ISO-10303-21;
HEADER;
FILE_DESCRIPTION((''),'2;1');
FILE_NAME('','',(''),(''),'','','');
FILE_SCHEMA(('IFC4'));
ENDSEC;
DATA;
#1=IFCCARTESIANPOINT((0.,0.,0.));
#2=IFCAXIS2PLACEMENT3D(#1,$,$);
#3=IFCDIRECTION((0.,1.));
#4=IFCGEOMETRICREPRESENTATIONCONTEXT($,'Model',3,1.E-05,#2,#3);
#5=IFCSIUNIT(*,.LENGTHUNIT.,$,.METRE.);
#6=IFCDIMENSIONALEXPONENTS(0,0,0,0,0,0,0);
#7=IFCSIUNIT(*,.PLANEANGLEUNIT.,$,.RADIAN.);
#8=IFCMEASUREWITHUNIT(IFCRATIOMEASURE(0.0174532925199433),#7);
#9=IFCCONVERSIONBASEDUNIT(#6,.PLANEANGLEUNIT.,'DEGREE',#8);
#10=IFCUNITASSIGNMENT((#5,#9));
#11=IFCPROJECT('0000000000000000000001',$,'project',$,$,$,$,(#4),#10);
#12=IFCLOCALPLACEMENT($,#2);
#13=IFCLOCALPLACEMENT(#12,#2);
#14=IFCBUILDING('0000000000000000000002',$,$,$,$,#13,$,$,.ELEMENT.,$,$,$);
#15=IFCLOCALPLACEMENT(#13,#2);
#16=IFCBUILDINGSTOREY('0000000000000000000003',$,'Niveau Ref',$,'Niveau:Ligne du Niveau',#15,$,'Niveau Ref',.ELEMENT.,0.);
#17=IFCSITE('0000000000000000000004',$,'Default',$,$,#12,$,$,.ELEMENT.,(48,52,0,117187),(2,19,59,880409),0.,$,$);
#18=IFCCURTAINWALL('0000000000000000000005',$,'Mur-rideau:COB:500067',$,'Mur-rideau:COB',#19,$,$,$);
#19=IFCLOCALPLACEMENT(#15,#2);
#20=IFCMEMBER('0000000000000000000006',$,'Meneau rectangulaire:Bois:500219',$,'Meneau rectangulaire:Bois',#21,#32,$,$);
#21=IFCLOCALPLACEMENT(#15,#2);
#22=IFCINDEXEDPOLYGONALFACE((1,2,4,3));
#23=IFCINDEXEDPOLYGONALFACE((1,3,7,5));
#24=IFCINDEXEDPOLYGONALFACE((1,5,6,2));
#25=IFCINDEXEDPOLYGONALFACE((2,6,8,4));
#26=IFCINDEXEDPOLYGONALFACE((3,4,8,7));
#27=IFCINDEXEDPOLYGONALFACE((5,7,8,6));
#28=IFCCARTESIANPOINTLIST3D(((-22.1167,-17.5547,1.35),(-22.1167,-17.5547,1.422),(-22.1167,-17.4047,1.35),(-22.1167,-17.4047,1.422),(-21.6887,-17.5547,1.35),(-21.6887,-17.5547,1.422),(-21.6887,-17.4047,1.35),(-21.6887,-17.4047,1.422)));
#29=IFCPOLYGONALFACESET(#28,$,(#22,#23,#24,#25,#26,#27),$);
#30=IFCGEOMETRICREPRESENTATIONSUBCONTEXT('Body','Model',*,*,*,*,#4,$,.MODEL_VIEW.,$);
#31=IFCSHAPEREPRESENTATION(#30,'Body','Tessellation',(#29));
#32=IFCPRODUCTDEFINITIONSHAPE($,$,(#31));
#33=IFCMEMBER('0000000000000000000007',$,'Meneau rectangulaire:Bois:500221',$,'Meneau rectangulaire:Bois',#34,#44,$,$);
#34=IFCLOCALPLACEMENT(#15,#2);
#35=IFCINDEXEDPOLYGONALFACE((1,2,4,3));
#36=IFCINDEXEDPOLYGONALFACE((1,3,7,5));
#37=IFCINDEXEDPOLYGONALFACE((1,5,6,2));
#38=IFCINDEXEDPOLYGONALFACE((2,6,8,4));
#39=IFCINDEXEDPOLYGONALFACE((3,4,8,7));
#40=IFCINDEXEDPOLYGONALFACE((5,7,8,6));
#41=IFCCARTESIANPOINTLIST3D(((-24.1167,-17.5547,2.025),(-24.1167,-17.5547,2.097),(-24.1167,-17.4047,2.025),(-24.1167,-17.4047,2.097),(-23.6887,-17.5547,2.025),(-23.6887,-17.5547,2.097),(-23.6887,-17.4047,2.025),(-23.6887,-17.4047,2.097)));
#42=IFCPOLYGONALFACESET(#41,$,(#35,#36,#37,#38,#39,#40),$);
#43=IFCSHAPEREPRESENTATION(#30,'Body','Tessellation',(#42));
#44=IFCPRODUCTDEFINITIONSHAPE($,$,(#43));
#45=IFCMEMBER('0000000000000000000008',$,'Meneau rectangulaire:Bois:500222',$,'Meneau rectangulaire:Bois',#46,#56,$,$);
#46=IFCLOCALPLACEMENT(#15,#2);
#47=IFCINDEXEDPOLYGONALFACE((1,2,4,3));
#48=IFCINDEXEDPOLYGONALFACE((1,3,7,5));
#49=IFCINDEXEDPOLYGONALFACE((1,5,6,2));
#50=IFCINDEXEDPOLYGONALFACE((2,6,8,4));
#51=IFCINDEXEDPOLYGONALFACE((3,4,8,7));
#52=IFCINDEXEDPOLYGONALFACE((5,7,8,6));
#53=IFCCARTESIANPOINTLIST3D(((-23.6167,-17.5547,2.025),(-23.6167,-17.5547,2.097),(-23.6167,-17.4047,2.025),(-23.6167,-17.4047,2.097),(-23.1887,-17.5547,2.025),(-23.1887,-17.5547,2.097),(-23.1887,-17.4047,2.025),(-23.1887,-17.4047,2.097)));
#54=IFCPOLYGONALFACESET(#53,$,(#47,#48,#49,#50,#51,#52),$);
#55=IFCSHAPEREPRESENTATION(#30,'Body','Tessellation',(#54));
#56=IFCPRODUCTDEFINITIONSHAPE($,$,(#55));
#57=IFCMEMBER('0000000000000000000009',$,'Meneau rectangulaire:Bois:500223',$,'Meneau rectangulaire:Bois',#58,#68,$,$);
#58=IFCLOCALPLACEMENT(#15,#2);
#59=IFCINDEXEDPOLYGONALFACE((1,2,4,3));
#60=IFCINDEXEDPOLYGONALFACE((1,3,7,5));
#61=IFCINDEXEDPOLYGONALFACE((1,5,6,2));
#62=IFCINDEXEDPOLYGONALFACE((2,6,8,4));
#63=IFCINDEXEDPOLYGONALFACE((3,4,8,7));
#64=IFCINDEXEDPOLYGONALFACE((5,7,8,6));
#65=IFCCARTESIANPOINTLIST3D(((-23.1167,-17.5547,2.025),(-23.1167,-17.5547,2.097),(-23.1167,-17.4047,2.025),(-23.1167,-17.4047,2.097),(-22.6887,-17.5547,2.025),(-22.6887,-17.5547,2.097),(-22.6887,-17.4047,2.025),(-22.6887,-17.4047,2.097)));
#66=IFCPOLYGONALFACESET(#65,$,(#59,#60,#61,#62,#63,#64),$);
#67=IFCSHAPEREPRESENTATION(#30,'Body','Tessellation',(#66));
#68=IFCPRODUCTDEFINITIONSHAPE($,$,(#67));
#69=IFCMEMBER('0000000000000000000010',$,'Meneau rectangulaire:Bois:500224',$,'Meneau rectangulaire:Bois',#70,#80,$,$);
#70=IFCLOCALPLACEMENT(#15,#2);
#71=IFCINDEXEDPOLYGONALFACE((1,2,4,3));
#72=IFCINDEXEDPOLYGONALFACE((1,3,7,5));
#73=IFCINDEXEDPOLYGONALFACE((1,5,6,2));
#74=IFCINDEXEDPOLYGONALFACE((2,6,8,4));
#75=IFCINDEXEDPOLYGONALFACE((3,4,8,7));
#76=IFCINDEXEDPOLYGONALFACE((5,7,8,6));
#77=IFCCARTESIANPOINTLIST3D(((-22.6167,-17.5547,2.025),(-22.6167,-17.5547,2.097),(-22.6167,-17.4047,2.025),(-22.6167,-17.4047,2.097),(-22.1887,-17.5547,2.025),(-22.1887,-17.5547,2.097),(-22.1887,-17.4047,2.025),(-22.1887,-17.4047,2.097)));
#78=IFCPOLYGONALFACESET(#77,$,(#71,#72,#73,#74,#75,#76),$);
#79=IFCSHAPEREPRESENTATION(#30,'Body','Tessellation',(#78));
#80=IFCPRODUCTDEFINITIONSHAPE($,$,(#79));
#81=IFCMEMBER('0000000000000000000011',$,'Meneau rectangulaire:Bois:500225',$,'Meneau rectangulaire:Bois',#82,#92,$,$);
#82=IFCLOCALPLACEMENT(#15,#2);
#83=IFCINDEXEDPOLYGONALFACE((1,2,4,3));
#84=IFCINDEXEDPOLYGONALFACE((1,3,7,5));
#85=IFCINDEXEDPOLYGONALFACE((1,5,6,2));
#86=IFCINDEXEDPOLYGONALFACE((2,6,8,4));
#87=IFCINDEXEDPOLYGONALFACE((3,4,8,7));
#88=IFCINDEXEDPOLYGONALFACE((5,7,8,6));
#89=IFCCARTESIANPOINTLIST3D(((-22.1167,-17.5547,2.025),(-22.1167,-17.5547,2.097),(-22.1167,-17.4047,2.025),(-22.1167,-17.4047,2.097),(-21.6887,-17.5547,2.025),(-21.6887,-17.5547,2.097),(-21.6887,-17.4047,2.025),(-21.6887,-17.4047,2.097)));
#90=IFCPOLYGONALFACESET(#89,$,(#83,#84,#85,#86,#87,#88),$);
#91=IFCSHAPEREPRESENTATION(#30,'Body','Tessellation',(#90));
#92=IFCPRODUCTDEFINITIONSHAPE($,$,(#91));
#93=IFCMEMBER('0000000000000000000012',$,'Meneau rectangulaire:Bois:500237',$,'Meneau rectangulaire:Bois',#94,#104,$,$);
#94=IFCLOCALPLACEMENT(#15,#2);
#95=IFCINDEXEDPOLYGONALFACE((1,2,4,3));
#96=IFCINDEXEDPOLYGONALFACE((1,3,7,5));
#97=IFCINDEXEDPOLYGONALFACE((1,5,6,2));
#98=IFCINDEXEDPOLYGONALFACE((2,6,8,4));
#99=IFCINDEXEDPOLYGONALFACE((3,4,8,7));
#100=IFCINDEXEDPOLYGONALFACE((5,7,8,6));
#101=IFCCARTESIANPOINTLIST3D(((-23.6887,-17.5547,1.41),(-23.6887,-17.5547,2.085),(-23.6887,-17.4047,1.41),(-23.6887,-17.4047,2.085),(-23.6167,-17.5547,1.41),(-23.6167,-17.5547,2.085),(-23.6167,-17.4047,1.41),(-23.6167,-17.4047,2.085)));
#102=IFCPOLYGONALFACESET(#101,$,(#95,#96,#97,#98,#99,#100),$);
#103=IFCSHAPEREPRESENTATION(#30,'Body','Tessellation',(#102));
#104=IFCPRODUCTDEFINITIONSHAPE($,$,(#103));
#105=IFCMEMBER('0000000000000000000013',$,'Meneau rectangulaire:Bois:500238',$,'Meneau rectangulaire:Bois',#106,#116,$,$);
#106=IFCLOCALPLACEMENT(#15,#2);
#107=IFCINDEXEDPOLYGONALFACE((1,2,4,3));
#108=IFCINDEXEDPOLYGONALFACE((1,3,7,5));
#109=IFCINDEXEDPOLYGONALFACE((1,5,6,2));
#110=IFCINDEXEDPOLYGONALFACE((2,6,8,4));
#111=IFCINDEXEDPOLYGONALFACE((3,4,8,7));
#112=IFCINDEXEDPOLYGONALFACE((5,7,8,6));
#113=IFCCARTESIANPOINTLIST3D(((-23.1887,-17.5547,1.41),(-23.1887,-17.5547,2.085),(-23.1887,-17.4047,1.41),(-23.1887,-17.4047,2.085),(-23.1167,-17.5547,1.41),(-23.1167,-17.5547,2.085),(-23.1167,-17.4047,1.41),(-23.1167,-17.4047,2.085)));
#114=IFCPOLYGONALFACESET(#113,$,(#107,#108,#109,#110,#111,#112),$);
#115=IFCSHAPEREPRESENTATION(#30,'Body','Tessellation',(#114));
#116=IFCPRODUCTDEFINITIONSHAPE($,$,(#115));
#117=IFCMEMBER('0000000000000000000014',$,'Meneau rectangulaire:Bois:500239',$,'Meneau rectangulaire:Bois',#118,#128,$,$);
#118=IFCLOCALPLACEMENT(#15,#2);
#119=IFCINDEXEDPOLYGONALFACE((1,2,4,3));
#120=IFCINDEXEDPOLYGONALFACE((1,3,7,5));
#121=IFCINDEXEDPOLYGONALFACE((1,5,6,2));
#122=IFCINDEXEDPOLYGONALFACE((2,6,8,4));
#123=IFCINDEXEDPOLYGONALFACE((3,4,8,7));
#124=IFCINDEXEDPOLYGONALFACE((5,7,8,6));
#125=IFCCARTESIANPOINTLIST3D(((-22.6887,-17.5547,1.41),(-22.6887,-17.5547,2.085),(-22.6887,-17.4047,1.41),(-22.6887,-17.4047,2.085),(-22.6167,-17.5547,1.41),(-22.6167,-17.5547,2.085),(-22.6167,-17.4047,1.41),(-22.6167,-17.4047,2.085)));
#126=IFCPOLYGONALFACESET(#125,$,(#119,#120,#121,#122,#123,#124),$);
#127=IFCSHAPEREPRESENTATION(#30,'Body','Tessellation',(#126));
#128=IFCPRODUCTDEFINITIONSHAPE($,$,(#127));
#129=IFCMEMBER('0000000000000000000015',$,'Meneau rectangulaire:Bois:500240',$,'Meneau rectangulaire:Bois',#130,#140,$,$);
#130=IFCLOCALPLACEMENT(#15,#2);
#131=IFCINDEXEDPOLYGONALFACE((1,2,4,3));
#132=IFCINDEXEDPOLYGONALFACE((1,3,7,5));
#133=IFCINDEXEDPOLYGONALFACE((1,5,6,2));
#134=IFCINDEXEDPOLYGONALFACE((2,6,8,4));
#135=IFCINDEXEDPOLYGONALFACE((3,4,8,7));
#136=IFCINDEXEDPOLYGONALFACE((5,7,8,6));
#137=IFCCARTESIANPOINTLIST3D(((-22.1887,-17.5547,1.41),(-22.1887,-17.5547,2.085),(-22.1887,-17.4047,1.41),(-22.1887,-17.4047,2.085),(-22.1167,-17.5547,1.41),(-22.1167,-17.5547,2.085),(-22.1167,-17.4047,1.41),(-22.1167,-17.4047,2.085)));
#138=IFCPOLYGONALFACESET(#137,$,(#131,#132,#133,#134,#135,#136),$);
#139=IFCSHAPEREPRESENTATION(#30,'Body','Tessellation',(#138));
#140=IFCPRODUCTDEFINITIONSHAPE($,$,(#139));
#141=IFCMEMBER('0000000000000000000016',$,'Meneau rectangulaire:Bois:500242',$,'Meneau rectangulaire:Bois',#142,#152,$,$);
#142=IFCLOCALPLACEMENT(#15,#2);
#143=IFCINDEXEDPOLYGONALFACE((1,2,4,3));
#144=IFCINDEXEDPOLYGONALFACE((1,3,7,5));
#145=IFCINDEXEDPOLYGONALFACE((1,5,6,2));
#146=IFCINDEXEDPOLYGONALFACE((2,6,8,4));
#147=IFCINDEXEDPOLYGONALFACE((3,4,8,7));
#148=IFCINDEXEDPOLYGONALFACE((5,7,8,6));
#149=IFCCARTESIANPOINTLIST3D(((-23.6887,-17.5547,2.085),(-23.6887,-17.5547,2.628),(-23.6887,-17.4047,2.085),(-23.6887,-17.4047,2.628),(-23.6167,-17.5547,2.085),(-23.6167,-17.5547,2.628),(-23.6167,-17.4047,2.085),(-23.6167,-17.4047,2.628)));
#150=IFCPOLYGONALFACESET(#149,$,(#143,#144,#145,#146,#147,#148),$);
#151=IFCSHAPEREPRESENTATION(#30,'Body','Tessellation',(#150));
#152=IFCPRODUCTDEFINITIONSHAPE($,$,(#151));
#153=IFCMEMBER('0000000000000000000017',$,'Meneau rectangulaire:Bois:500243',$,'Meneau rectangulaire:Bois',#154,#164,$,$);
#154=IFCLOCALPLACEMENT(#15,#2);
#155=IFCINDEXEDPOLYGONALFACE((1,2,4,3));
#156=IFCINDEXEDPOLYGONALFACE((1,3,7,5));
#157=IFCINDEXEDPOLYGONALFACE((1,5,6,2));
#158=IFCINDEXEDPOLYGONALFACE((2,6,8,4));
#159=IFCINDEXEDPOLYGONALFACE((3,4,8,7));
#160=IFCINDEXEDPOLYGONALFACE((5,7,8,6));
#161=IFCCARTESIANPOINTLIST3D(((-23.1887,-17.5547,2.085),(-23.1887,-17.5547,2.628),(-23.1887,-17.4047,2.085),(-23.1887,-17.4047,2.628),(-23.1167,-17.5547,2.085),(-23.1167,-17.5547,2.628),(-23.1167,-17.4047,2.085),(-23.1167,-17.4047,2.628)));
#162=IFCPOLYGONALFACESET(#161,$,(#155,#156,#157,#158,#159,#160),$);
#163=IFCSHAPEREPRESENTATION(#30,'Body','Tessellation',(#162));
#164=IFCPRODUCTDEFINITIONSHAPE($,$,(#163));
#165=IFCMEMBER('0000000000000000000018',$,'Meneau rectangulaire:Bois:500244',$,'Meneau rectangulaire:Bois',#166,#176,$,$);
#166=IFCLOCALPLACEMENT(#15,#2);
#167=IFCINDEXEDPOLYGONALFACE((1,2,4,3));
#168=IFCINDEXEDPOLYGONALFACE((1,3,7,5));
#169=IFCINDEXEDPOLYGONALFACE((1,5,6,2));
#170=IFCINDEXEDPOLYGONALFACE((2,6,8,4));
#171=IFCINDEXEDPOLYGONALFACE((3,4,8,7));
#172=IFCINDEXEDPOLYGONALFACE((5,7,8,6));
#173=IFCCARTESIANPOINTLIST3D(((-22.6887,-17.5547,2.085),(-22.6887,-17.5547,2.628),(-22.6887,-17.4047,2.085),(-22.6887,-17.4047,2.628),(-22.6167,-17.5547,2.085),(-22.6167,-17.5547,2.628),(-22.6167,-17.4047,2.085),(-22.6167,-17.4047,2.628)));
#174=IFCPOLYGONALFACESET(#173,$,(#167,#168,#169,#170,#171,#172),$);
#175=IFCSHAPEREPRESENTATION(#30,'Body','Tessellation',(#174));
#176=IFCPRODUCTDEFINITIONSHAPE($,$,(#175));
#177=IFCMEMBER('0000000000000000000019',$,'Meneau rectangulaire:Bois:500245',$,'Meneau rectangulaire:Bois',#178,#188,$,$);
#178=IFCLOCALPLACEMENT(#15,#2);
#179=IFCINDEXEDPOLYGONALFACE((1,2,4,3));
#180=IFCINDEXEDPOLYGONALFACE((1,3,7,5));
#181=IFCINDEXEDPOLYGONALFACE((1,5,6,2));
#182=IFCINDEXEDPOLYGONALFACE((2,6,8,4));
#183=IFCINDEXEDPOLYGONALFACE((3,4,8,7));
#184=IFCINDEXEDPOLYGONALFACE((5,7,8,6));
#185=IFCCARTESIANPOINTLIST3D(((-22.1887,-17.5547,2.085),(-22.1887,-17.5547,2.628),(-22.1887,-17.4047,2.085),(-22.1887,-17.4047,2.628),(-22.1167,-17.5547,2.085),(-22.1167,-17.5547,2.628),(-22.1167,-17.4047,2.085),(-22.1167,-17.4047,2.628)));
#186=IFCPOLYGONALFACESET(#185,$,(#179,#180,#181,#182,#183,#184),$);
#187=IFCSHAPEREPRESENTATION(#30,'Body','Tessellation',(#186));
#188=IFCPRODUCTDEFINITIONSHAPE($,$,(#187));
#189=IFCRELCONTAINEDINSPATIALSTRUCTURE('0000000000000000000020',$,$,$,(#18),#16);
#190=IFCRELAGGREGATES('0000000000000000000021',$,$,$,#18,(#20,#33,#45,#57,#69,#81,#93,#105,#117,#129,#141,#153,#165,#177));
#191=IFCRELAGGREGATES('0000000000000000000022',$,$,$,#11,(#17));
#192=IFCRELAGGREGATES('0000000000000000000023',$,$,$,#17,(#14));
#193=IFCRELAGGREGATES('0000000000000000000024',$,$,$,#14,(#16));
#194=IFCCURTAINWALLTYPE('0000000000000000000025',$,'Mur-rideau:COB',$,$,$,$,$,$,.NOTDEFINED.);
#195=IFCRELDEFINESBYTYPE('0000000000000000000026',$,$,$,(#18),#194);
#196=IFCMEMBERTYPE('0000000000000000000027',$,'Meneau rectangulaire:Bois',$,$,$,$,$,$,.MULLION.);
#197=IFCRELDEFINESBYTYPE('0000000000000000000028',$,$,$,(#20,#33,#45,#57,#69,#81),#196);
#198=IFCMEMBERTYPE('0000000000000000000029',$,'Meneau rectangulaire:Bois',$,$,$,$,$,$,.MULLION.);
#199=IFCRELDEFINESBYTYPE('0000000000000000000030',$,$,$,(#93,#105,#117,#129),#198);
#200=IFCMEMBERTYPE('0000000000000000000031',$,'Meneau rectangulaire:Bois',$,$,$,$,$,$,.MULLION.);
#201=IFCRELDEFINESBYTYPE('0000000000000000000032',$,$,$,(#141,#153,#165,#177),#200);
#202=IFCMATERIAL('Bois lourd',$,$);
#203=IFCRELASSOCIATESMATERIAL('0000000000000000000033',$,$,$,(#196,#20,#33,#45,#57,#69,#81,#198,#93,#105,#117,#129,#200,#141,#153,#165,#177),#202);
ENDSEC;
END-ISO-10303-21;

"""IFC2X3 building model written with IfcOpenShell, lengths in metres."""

from ifc_helpers import new_model, entity, si_unit, converted_unit, direction, frame, origin, origin_2d_with_axis, place, context, subcontext, project, spatial, rectangle, extrude, source, transform, mapped, material, type_object, type_shapes, element, aggregate, save


model = new_model("IFC2X3")

# Units and contexts
model_context = context("Model", 3, precision=1e-05, world=origin(), true_north=direction((0.0, 1.0)))
body_context = subcontext(model_context, "Body", "Model", "MODEL_VIEW")
ifc_project = project(units=[si_unit("LENGTHUNIT", "METRE"), converted_unit("PLANEANGLEUNIT", "DEGREE", entity("IfcRatioMeasure", 0.0174532925199433), si_unit("PLANEANGLEUNIT", "RADIAN"), dimensions=[0, 0, 0, 0, 0, 0, 0])], contexts=[model_context])

# Site, building, storey
site_placement = place(None, origin())
site = spatial("IfcSite", under=ifc_project, at=site_placement, Name="Default", CompositionType="ELEMENT", RefLatitude=(48, 52, 0, 117187), RefLongitude=(2, 19, 59, 880409), RefElevation=0.0)
building_placement = place(site_placement, origin())
building = spatial("IfcBuilding", under=site, at=building_placement, CompositionType="ELEMENT")
storey_placement = place(building_placement, origin())
storey = spatial("IfcBuildingStorey", under=building, at=storey_placement, Name="Niveau Ref", ObjectType="Niveau:Ligne du Niveau", LongName="Niveau Ref", CompositionType="ELEMENT", Elevation=0.0)

# Curtain wall, members
curtain_wall_type = type_object("IfcCurtainWallType", Name="Mur-rideau:COB", PredefinedType="NOTDEFINED")
curtain_wall_placement = place(storey_placement, origin())
curtain_wall = element("IfcCurtainWall", 1, at=curtain_wall_placement, inside=storey, type_object=curtain_wall_type, Name="Mur-rideau:COB:500067", ObjectType="Mur-rideau:COB")
ifc_material = material(Name="Bois lourd")
member_type_1 = type_object("IfcMemberType", Name="Meneau rectangulaire:Bois", PredefinedType="MULLION", material=ifc_material)
shared_shape_1 = source(origin(), body_context, "Body", "SweptSolid", [
    extrude(rectangle(XDim=0.15, YDim=0.072, at=origin_2d_with_axis()), frame((-0.024, 0.0, -0.428), z_axis=(0.0, 0.0, 1.0), x_axis=(0.0, -1.0, 0.0)), (0.0, 0.0, 1.0), 0.428),
])
type_shapes(member_type_1, [shared_shape_1])
member_1_placement = place(storey_placement, frame((-21.6887, -17.4797, 1.41), z_axis=(1.0, 0.0, 0.0), x_axis=(0.0, 0.0, 1.0)))
member_1 = element("IfcMember", 2, at=member_1_placement, type_object=member_type_1, material=ifc_material, Name="Meneau rectangulaire:Bois:500219", ObjectType="Meneau rectangulaire:Bois", context=body_context, shape_type="MappedRepresentation", body=[
    mapped(shared_shape_1, transform((0.0, 0.0, 0.0), scale=1.0)),
])
member_2_placement = place(storey_placement, frame((-23.6887, -17.4797, 2.085), z_axis=(1.0, 0.0, 0.0), x_axis=(0.0, 0.0, 1.0)))
member_2 = element("IfcMember", 3, at=member_2_placement, type_object=member_type_1, material=ifc_material, Name="Meneau rectangulaire:Bois:500221", ObjectType="Meneau rectangulaire:Bois", context=body_context, shape_type="MappedRepresentation", body=[
    mapped(shared_shape_1, transform((0.0, 0.0, 0.0), scale=1.0)),
])
member_3_placement = place(storey_placement, frame((-23.1887, -17.4797, 2.085), z_axis=(1.0, 0.0, 0.0), x_axis=(0.0, 0.0, 1.0)))
member_3 = element("IfcMember", 4, at=member_3_placement, type_object=member_type_1, material=ifc_material, Name="Meneau rectangulaire:Bois:500222", ObjectType="Meneau rectangulaire:Bois", context=body_context, shape_type="MappedRepresentation", body=[
    mapped(shared_shape_1, transform((0.0, 0.0, 0.0), scale=1.0)),
])
member_4_placement = place(storey_placement, frame((-22.6887, -17.4797, 2.085), z_axis=(1.0, 0.0, 0.0), x_axis=(0.0, 0.0, 1.0)))
member_4 = element("IfcMember", 5, at=member_4_placement, type_object=member_type_1, material=ifc_material, Name="Meneau rectangulaire:Bois:500223", ObjectType="Meneau rectangulaire:Bois", context=body_context, shape_type="MappedRepresentation", body=[
    mapped(shared_shape_1, transform((0.0, 0.0, 0.0), scale=1.0)),
])
member_5_placement = place(storey_placement, frame((-22.1887, -17.4797, 2.085), z_axis=(1.0, 0.0, 0.0), x_axis=(0.0, 0.0, 1.0)))
member_5 = element("IfcMember", 6, at=member_5_placement, type_object=member_type_1, material=ifc_material, Name="Meneau rectangulaire:Bois:500224", ObjectType="Meneau rectangulaire:Bois", context=body_context, shape_type="MappedRepresentation", body=[
    mapped(shared_shape_1, transform((0.0, 0.0, 0.0), scale=1.0)),
])
member_6_placement = place(storey_placement, frame((-21.6887, -17.4797, 2.085), z_axis=(1.0, 0.0, 0.0), x_axis=(0.0, 0.0, 1.0)))
member_6 = element("IfcMember", 7, at=member_6_placement, type_object=member_type_1, material=ifc_material, Name="Meneau rectangulaire:Bois:500225", ObjectType="Meneau rectangulaire:Bois", context=body_context, shape_type="MappedRepresentation", body=[
    mapped(shared_shape_1, transform((0.0, 0.0, 0.0), scale=1.0)),
])
member_type_2 = type_object("IfcMemberType", Name="Meneau rectangulaire:Bois", PredefinedType="MULLION", material=ifc_material)
shared_shape_2 = source(origin(), body_context, "Body", "SweptSolid", [
    extrude(rectangle(XDim=0.15, YDim=0.072, at=origin_2d_with_axis()), frame((-0.024, 0.0, -0.675), z_axis=(0.0, 0.0, 1.0), x_axis=(0.0, -1.0, 0.0)), (0.0, 0.0, 1.0), 0.675),
])
type_shapes(member_type_2, [shared_shape_2])
member_7_placement = place(storey_placement, frame((-23.6287, -17.4797, 1.41), z_axis=(0.0, 0.0, -1.0), x_axis=(1.0, 0.0, 0.0)))
member_7 = element("IfcMember", 8, at=member_7_placement, type_object=member_type_2, material=ifc_material, Name="Meneau rectangulaire:Bois:500237", ObjectType="Meneau rectangulaire:Bois", context=body_context, shape_type="MappedRepresentation", body=[
    mapped(shared_shape_2, transform((0.0, 0.0, 0.0), scale=1.0)),
])
member_8_placement = place(storey_placement, frame((-23.1287, -17.4797, 1.41), z_axis=(0.0, 0.0, -1.0), x_axis=(1.0, 0.0, 0.0)))
member_8 = element("IfcMember", 9, at=member_8_placement, type_object=member_type_2, material=ifc_material, Name="Meneau rectangulaire:Bois:500238", ObjectType="Meneau rectangulaire:Bois", context=body_context, shape_type="MappedRepresentation", body=[
    mapped(shared_shape_2, transform((0.0, 0.0, 0.0), scale=1.0)),
])
member_9_placement = place(storey_placement, frame((-22.6287, -17.4797, 1.41), z_axis=(0.0, 0.0, -1.0), x_axis=(1.0, 0.0, 0.0)))
member_9 = element("IfcMember", 10, at=member_9_placement, type_object=member_type_2, material=ifc_material, Name="Meneau rectangulaire:Bois:500239", ObjectType="Meneau rectangulaire:Bois", context=body_context, shape_type="MappedRepresentation", body=[
    mapped(shared_shape_2, transform((0.0, 0.0, 0.0), scale=1.0)),
])
member_10_placement = place(storey_placement, frame((-22.1287, -17.4797, 1.41), z_axis=(0.0, 0.0, -1.0), x_axis=(1.0, 0.0, 0.0)))
member_10 = element("IfcMember", 11, at=member_10_placement, type_object=member_type_2, material=ifc_material, Name="Meneau rectangulaire:Bois:500240", ObjectType="Meneau rectangulaire:Bois", context=body_context, shape_type="MappedRepresentation", body=[
    mapped(shared_shape_2, transform((0.0, 0.0, 0.0), scale=1.0)),
])
member_type_3 = type_object("IfcMemberType", Name="Meneau rectangulaire:Bois", PredefinedType="MULLION", material=ifc_material)
shared_shape_3 = source(origin(), body_context, "Body", "SweptSolid", [
    extrude(rectangle(XDim=0.15, YDim=0.072, at=origin_2d_with_axis()), frame((-0.024, 0.0, -0.543), z_axis=(0.0, 0.0, 1.0), x_axis=(0.0, -1.0, 0.0)), (0.0, 0.0, 1.0), 0.543),
])
type_shapes(member_type_3, [shared_shape_3])
member_11_placement = place(storey_placement, frame((-23.6287, -17.4797, 2.085), z_axis=(0.0, 0.0, -1.0), x_axis=(1.0, 0.0, 0.0)))
member_11 = element("IfcMember", 12, at=member_11_placement, type_object=member_type_3, material=ifc_material, Name="Meneau rectangulaire:Bois:500242", ObjectType="Meneau rectangulaire:Bois", context=body_context, shape_type="MappedRepresentation", body=[
    mapped(shared_shape_3, transform((0.0, 0.0, 0.0), scale=1.0)),
])
member_12_placement = place(storey_placement, frame((-23.1287, -17.4797, 2.085), z_axis=(0.0, 0.0, -1.0), x_axis=(1.0, 0.0, 0.0)))
member_12 = element("IfcMember", 13, at=member_12_placement, type_object=member_type_3, material=ifc_material, Name="Meneau rectangulaire:Bois:500243", ObjectType="Meneau rectangulaire:Bois", context=body_context, shape_type="MappedRepresentation", body=[
    mapped(shared_shape_3, transform((0.0, 0.0, 0.0), scale=1.0)),
])
member_13_placement = place(storey_placement, frame((-22.6287, -17.4797, 2.085), z_axis=(0.0, 0.0, -1.0), x_axis=(1.0, 0.0, 0.0)))
member_13 = element("IfcMember", 14, at=member_13_placement, type_object=member_type_3, material=ifc_material, Name="Meneau rectangulaire:Bois:500244", ObjectType="Meneau rectangulaire:Bois", context=body_context, shape_type="MappedRepresentation", body=[
    mapped(shared_shape_3, transform((0.0, 0.0, 0.0), scale=1.0)),
])
member_14_placement = place(storey_placement, frame((-22.1287, -17.4797, 2.085), z_axis=(0.0, 0.0, -1.0), x_axis=(1.0, 0.0, 0.0)))
member_14 = element("IfcMember", 15, at=member_14_placement, type_object=member_type_3, material=ifc_material, Name="Meneau rectangulaire:Bois:500245", ObjectType="Meneau rectangulaire:Bois", context=body_context, shape_type="MappedRepresentation", body=[
    mapped(shared_shape_3, transform((0.0, 0.0, 0.0), scale=1.0)),
])
aggregate(curtain_wall, [member_1, member_2, member_3, member_4, member_5, member_6, member_7, member_8, member_9, member_10, member_11, member_12, member_13, member_14])

save(model, "model.ifc")
